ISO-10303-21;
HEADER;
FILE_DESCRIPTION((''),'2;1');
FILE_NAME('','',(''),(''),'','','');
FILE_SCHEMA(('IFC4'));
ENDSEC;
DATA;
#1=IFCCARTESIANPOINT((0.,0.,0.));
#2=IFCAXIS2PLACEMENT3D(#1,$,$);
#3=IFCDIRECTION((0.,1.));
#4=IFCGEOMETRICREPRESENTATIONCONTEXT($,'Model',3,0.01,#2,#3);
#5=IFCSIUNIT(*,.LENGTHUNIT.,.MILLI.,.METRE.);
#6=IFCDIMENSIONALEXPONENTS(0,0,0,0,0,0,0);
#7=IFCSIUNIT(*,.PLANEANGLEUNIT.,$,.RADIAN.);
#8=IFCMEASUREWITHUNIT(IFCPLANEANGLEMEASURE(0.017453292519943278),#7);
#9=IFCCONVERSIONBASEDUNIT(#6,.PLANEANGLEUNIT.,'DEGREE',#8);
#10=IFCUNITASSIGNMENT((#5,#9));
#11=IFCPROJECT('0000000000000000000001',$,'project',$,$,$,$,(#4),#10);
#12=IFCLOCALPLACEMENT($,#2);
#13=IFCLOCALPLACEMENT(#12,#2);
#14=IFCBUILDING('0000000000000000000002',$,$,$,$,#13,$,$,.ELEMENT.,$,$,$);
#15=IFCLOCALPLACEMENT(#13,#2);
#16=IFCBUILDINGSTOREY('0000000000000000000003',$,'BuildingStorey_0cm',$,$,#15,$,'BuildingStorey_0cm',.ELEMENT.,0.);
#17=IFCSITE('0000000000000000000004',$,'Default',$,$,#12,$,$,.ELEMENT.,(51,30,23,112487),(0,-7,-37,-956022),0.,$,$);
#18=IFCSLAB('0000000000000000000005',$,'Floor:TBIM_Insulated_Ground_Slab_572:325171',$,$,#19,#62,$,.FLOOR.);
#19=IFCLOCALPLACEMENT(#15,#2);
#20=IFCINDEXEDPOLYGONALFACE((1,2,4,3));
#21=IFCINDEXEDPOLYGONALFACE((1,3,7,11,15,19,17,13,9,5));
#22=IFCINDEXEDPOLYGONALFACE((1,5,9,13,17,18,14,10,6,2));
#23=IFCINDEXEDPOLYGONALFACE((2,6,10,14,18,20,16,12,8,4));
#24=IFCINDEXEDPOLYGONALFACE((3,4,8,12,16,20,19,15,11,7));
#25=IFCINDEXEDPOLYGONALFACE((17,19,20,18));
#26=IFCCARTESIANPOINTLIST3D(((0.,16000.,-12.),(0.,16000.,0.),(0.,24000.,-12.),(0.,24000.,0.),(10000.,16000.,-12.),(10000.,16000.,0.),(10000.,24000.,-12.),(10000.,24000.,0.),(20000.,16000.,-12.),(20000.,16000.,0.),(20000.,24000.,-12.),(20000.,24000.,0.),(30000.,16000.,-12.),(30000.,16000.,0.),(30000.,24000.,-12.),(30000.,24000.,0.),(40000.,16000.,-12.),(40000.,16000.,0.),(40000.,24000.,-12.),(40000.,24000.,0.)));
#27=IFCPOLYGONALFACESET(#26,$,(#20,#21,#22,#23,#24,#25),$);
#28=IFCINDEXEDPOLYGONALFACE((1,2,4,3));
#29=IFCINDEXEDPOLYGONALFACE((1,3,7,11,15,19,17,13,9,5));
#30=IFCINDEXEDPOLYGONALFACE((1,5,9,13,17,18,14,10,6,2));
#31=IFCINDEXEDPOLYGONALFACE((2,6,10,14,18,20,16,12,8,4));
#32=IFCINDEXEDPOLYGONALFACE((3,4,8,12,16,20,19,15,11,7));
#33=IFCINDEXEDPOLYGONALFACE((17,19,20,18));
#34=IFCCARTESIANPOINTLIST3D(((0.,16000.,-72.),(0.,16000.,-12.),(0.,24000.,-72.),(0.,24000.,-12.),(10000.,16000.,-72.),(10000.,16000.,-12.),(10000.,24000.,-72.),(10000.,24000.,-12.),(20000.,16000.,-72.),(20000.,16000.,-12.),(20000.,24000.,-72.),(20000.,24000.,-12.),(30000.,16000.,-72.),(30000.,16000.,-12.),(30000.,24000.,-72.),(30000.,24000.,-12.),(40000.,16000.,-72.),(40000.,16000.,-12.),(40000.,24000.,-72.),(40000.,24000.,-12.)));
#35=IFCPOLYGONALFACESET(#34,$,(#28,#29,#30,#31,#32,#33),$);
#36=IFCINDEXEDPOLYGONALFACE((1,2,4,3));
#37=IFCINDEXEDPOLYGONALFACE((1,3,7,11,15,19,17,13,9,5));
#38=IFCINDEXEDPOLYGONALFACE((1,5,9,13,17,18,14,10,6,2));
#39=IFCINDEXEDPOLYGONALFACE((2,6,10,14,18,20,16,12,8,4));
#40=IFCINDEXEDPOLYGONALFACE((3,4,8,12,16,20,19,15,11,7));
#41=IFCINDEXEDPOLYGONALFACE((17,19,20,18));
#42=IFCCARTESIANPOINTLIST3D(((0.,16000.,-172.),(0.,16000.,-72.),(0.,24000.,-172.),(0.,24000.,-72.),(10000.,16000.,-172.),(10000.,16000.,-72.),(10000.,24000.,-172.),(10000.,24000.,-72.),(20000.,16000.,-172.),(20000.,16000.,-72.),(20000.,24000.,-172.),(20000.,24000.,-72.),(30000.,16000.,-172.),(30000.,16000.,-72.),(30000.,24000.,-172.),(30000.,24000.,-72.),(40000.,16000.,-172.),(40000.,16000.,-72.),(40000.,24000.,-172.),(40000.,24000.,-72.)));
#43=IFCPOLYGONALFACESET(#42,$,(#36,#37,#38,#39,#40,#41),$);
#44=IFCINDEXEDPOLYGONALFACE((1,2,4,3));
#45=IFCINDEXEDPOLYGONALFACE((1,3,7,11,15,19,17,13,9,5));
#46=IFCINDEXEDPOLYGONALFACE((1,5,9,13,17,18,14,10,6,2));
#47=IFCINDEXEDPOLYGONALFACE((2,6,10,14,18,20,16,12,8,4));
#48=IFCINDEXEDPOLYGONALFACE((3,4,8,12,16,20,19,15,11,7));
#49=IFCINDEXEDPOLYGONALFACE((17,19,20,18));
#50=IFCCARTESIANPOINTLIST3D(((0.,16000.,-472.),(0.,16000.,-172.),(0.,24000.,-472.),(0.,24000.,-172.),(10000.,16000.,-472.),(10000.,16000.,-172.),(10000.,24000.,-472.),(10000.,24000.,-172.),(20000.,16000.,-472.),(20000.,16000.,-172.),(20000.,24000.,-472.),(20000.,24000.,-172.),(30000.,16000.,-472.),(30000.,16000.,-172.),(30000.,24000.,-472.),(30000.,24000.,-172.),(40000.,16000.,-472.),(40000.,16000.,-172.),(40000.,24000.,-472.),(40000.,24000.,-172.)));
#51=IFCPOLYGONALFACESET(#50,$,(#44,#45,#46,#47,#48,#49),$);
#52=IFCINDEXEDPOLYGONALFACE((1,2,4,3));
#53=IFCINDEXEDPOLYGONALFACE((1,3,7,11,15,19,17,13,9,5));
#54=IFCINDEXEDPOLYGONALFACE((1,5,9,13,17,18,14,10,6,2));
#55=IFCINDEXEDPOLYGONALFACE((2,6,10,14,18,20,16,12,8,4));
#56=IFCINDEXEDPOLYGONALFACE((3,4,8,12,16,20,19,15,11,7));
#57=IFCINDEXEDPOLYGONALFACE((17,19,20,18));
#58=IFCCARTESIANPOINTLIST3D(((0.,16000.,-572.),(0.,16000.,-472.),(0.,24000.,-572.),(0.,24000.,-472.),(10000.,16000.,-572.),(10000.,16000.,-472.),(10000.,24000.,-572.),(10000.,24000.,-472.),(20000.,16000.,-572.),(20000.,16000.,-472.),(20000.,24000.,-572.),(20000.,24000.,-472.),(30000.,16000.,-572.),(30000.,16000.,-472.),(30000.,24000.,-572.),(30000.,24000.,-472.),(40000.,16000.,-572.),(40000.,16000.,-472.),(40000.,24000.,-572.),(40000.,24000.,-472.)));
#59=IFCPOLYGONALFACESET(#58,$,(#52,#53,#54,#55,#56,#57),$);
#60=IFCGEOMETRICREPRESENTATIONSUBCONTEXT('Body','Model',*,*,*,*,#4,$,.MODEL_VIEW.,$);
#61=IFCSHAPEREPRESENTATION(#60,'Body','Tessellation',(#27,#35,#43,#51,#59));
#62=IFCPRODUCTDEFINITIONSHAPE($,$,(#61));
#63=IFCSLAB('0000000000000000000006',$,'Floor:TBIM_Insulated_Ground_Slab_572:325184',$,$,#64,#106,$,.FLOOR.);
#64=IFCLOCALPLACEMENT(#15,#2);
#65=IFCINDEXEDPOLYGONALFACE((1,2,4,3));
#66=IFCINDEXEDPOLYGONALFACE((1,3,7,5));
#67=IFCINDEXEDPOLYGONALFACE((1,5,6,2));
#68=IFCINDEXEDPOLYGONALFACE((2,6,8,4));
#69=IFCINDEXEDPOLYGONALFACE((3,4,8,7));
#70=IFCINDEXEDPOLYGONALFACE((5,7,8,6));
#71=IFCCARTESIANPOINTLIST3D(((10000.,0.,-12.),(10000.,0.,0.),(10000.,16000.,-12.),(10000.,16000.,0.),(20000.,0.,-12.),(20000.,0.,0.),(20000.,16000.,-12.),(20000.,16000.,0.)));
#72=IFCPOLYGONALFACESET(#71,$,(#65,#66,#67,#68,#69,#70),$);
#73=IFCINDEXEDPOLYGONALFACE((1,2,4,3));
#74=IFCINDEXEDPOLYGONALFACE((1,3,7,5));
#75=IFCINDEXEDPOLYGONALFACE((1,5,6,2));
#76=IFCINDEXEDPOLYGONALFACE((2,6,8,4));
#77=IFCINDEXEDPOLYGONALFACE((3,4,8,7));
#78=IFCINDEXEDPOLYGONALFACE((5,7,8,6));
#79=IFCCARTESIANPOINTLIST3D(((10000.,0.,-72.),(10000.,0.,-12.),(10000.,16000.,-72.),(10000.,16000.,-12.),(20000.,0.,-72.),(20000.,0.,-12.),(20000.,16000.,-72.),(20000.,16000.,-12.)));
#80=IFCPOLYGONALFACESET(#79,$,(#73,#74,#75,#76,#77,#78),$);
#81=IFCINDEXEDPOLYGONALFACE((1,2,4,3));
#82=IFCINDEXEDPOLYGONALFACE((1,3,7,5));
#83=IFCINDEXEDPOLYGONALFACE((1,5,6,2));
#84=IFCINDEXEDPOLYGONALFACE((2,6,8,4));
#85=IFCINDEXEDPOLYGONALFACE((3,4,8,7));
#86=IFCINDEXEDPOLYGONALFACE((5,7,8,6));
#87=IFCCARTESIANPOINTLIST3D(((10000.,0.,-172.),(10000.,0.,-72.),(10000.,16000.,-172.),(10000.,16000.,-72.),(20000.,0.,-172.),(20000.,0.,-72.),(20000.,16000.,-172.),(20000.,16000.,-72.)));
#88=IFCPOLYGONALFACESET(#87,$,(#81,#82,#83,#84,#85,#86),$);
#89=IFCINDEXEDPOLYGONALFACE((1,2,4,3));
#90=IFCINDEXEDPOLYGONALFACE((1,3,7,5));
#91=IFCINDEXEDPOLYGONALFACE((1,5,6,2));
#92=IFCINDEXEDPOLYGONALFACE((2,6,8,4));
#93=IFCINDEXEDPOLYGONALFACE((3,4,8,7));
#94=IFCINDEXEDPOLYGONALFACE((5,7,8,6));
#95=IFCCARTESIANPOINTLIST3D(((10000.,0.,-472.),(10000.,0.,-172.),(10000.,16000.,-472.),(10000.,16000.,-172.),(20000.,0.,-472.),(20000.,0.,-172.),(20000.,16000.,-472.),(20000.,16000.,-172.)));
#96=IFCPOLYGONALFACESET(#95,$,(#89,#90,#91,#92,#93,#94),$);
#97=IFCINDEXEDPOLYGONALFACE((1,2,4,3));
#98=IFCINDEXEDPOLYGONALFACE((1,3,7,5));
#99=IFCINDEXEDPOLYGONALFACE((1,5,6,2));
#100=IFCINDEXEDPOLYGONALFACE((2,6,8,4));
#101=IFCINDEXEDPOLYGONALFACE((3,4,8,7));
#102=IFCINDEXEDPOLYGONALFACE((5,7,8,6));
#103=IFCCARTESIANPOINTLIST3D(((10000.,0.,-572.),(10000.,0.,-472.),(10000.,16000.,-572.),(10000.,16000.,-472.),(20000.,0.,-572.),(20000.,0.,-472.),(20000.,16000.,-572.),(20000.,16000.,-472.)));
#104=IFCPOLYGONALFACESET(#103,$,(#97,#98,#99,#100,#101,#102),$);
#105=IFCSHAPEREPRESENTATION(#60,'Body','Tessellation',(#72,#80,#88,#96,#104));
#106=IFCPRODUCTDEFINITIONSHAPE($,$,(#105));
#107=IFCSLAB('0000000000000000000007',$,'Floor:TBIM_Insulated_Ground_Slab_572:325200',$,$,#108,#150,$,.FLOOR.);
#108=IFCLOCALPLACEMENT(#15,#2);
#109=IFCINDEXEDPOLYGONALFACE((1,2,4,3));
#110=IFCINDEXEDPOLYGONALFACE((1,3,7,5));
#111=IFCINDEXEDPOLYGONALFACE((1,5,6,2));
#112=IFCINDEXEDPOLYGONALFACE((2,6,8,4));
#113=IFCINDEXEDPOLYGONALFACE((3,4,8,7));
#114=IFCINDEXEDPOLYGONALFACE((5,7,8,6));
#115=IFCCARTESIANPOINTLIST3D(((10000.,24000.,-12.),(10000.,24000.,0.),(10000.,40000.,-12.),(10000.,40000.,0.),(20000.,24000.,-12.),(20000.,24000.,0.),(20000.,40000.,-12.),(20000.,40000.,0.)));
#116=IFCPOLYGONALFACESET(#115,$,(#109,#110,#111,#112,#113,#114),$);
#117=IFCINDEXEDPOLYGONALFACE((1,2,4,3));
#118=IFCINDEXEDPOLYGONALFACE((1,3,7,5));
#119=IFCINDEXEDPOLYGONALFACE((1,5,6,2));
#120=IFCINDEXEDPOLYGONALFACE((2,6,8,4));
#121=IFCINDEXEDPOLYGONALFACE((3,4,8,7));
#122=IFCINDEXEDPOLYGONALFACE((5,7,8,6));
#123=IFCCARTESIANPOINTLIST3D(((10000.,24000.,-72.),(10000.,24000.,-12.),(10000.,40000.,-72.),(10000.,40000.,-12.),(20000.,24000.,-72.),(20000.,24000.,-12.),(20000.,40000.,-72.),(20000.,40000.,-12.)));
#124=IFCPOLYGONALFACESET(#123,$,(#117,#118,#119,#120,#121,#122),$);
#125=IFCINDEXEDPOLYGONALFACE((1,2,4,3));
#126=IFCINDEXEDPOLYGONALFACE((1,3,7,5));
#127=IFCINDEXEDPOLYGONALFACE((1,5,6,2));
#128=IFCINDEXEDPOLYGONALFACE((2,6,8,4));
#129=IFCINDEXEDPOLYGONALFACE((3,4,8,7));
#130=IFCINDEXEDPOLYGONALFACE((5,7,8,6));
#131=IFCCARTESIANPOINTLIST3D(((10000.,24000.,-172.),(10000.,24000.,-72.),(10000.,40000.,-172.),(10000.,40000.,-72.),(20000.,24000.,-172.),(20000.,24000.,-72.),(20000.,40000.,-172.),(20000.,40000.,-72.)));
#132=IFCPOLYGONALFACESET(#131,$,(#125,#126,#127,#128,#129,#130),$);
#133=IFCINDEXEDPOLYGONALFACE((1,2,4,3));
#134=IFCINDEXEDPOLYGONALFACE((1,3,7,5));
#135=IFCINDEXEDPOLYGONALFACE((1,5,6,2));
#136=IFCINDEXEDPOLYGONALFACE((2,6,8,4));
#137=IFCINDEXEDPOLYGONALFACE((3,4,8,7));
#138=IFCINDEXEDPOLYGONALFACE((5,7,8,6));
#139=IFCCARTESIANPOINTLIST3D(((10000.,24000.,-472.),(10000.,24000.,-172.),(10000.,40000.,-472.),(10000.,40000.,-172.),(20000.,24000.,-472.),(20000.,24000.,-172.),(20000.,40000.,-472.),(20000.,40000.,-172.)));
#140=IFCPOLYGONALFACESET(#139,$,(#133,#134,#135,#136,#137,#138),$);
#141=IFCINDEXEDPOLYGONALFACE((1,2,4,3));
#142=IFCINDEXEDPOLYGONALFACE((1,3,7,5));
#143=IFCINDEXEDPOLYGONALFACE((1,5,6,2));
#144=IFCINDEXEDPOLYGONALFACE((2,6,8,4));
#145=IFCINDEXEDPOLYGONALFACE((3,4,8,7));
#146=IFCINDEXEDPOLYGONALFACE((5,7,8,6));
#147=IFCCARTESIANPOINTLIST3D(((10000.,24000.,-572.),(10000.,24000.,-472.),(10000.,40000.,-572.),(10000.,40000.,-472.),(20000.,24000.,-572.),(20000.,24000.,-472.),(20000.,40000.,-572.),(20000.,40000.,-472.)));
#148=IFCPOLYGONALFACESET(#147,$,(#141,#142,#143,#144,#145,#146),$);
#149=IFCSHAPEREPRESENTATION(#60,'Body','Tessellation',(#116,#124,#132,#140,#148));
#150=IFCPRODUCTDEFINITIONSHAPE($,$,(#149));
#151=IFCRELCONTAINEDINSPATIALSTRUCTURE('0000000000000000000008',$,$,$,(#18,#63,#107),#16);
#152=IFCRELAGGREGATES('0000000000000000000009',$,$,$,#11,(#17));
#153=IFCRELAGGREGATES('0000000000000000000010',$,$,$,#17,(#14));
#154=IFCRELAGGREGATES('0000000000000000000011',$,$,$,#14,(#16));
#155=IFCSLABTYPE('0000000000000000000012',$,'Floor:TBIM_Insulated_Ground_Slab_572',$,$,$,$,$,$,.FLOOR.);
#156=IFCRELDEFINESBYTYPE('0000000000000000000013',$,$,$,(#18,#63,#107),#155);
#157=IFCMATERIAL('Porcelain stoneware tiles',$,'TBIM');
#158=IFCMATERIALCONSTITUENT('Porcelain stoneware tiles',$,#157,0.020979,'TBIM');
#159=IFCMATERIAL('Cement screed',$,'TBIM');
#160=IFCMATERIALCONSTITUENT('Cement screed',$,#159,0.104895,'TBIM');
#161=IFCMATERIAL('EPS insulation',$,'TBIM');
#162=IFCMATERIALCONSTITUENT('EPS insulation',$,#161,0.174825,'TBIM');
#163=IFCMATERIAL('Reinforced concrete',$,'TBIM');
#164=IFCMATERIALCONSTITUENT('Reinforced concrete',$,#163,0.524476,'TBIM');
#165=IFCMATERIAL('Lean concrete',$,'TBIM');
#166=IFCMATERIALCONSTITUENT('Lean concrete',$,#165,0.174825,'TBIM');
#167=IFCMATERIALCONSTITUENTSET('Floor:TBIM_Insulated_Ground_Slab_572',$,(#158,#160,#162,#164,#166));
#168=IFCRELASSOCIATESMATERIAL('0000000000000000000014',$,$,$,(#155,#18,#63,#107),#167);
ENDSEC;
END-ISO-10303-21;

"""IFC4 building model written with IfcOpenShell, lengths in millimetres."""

from ifc_helpers import new_model, entity, si_unit, converted_unit, direction, frame, origin, place, context, subcontext, project, spatial, indexed_curve, outline, extrude, material, constituent, constituent_set, type_object, element, save


model = new_model("IFC4")

# Units and contexts
model_context = context("Model", 3, precision=0.01, world=origin(), true_north=direction((0.0, 1.0)))
body_context = subcontext(model_context, "Body", "Model", "MODEL_VIEW")
ifc_project = project(units=[si_unit("LENGTHUNIT", "METRE", prefix="MILLI"), converted_unit("PLANEANGLEUNIT", "DEGREE", entity("IfcPlaneAngleMeasure", 0.017453292519943278), si_unit("PLANEANGLEUNIT", "RADIAN"), dimensions=[0, 0, 0, 0, 0, 0, 0])], contexts=[model_context])

# Site, building, storey
site_placement = place(None, origin())
site = spatial("IfcSite", under=ifc_project, at=site_placement, Name="Default", CompositionType="ELEMENT", RefLatitude=(51, 30, 23, 112487), RefLongitude=(0, -7, -37, -956022), RefElevation=0.0)
building_placement = place(site_placement, origin())
building = spatial("IfcBuilding", under=site, at=building_placement, CompositionType="ELEMENT")
storey_placement = place(building_placement, origin())
storey = spatial("IfcBuildingStorey", under=building, at=storey_placement, Name="BuildingStorey_0cm", LongName="BuildingStorey_0cm", CompositionType="ELEMENT", Elevation=0.0)

# Slabs
ifc_material_1 = material(Name="Porcelain stoneware tiles", Category="TBIM")
ifc_constituent_1 = constituent(ifc_material_1, Name="Porcelain stoneware tiles", Category="TBIM", fraction=0.020979)
ifc_material_2 = material(Name="Cement screed", Category="TBIM")
ifc_constituent_2 = constituent(ifc_material_2, Name="Cement screed", Category="TBIM", fraction=0.104895)
ifc_material_3 = material(Name="EPS insulation", Category="TBIM")
ifc_constituent_3 = constituent(ifc_material_3, Name="EPS insulation", Category="TBIM", fraction=0.174825)
ifc_material_4 = material(Name="Reinforced concrete", Category="TBIM")
ifc_constituent_4 = constituent(ifc_material_4, Name="Reinforced concrete", Category="TBIM", fraction=0.524476)
ifc_material_5 = material(Name="Lean concrete", Category="TBIM")
ifc_constituent_5 = constituent(ifc_material_5, Name="Lean concrete", Category="TBIM", fraction=0.174825)
ifc_constituent_set_1 = constituent_set(constituents=[ifc_constituent_1, ifc_constituent_2, ifc_constituent_3, ifc_constituent_4, ifc_constituent_5], Name="Floor:TBIM_Insulated_Ground_Slab_572")
slab_type = type_object("IfcSlabType", Name="Floor:TBIM_Insulated_Ground_Slab_572", PredefinedType="FLOOR", material=ifc_constituent_set_1)
slab_1_placement = place(storey_placement, origin())
element("IfcSlab", 1, at=slab_1_placement, inside=storey, type_object=slab_type, material=ifc_constituent_set_1, Name="Floor:TBIM_Insulated_Ground_Slab_572:325171", PredefinedType="FLOOR", context=body_context, shape_type="SweptSolid", body=[
    extrude(outline(indexed_curve([(0.0, -4000.0), (10000.0, -4000.0), (20000.0, -4000.0), (20000.0, 4000.0), (10000.0, 4000.0), (0.0, 4000.0), (-10000.0, 4000.0), (-20000.0, 4000.0), (-20000.0, -4000.0), (-10000.0, -4000.0), (0.0, -4000.0)], self_intersect=False)), frame((20000.0, 20000.0, -12.0), z_axis=(0.0, 0.0, 1.0), x_axis=(-1.0, 0.0, 0.0)), (0.0, 0.0, 1.0), 12.0),
    extrude(outline(indexed_curve([(0.0, -4000.0), (10000.0, -4000.0), (20000.0, -4000.0), (20000.0, 4000.0), (10000.0, 4000.0), (0.0, 4000.0), (-10000.0, 4000.0), (-20000.0, 4000.0), (-20000.0, -4000.0), (-10000.0, -4000.0), (0.0, -4000.0)], self_intersect=False)), frame((20000.0, 20000.0, -72.0), z_axis=(0.0, 0.0, 1.0), x_axis=(-1.0, 0.0, 0.0)), (0.0, 0.0, 1.0), 60.0),
    extrude(outline(indexed_curve([(0.0, -4000.0), (10000.0, -4000.0), (20000.0, -4000.0), (20000.0, 4000.0), (10000.0, 4000.0), (0.0, 4000.0), (-10000.0, 4000.0), (-20000.0, 4000.0), (-20000.0, -4000.0), (-10000.0, -4000.0), (0.0, -4000.0)], self_intersect=False)), frame((20000.0, 20000.0, -172.0), z_axis=(0.0, 0.0, 1.0), x_axis=(-1.0, 0.0, 0.0)), (0.0, 0.0, 1.0), 100.0),
    extrude(outline(indexed_curve([(0.0, -4000.0), (10000.0, -4000.0), (20000.0, -4000.0), (20000.0, 4000.0), (10000.0, 4000.0), (0.0, 4000.0), (-10000.0, 4000.0), (-20000.0, 4000.0), (-20000.0, -4000.0), (-10000.0, -4000.0), (0.0, -4000.0)], self_intersect=False)), frame((20000.0, 20000.0, -472.0), z_axis=(0.0, 0.0, 1.0), x_axis=(-1.0, 0.0, 0.0)), (0.0, 0.0, 1.0), 300.0),
    extrude(outline(indexed_curve([(0.0, -4000.0), (10000.0, -4000.0), (20000.0, -4000.0), (20000.0, 4000.0), (10000.0, 4000.0), (0.0, 4000.0), (-10000.0, 4000.0), (-20000.0, 4000.0), (-20000.0, -4000.0), (-10000.0, -4000.0), (0.0, -4000.0)], self_intersect=False)), frame((20000.0, 20000.0, -572.0), z_axis=(0.0, 0.0, 1.0), x_axis=(-1.0, 0.0, 0.0)), (0.0, 0.0, 1.0), 100.0),
])
slab_2_placement = place(storey_placement, origin())
element("IfcSlab", 2, at=slab_2_placement, inside=storey, type_object=slab_type, material=ifc_constituent_set_1, Name="Floor:TBIM_Insulated_Ground_Slab_572:325184", PredefinedType="FLOOR", context=body_context, shape_type="SweptSolid", body=[
    extrude(outline(indexed_curve([(-5000.0, -8000.0), (5000.0, -8000.0), (5000.0, 8000.0), (-5000.0, 8000.0), (-5000.0, -8000.0)], self_intersect=False)), frame((15000.0, 8000.0, -12.0), z_axis=(0.0, 0.0, 1.0), x_axis=(-1.0, 0.0, 0.0)), (0.0, 0.0, 1.0), 12.0),
    extrude(outline(indexed_curve([(-5000.0, -8000.0), (5000.0, -8000.0), (5000.0, 8000.0), (-5000.0, 8000.0), (-5000.0, -8000.0)], self_intersect=False)), frame((15000.0, 8000.0, -72.0), z_axis=(0.0, 0.0, 1.0), x_axis=(-1.0, 0.0, 0.0)), (0.0, 0.0, 1.0), 60.0),
    extrude(outline(indexed_curve([(-5000.0, -8000.0), (5000.0, -8000.0), (5000.0, 8000.0), (-5000.0, 8000.0), (-5000.0, -8000.0)], self_intersect=False)), frame((15000.0, 8000.0, -172.0), z_axis=(0.0, 0.0, 1.0), x_axis=(-1.0, 0.0, 0.0)), (0.0, 0.0, 1.0), 100.0),
    extrude(outline(indexed_curve([(-5000.0, -8000.0), (5000.0, -8000.0), (5000.0, 8000.0), (-5000.0, 8000.0), (-5000.0, -8000.0)], self_intersect=False)), frame((15000.0, 8000.0, -472.0), z_axis=(0.0, 0.0, 1.0), x_axis=(-1.0, 0.0, 0.0)), (0.0, 0.0, 1.0), 300.0),
    extrude(outline(indexed_curve([(-5000.0, -8000.0), (5000.0, -8000.0), (5000.0, 8000.0), (-5000.0, 8000.0), (-5000.0, -8000.0)], self_intersect=False)), frame((15000.0, 8000.0, -572.0), z_axis=(0.0, 0.0, 1.0), x_axis=(-1.0, 0.0, 0.0)), (0.0, 0.0, 1.0), 100.0),
])
slab_3_placement = place(storey_placement, origin())
element("IfcSlab", 3, at=slab_3_placement, inside=storey, type_object=slab_type, material=ifc_constituent_set_1, Name="Floor:TBIM_Insulated_Ground_Slab_572:325200", PredefinedType="FLOOR", context=body_context, shape_type="SweptSolid", body=[
    extrude(outline(indexed_curve([(-5000.0, -8000.0), (5000.0, -8000.0), (5000.0, 8000.0), (-5000.0, 8000.0), (-5000.0, -8000.0)], self_intersect=False)), frame((15000.0, 32000.0, -12.0), z_axis=(0.0, 0.0, 1.0), x_axis=(-1.0, 0.0, 0.0)), (0.0, 0.0, 1.0), 12.0),
    extrude(outline(indexed_curve([(-5000.0, -8000.0), (5000.0, -8000.0), (5000.0, 8000.0), (-5000.0, 8000.0), (-5000.0, -8000.0)], self_intersect=False)), frame((15000.0, 32000.0, -72.0), z_axis=(0.0, 0.0, 1.0), x_axis=(-1.0, 0.0, 0.0)), (0.0, 0.0, 1.0), 60.0),
    extrude(outline(indexed_curve([(-5000.0, -8000.0), (5000.0, -8000.0), (5000.0, 8000.0), (-5000.0, 8000.0), (-5000.0, -8000.0)], self_intersect=False)), frame((15000.0, 32000.0, -172.0), z_axis=(0.0, 0.0, 1.0), x_axis=(-1.0, 0.0, 0.0)), (0.0, 0.0, 1.0), 100.0),
    extrude(outline(indexed_curve([(-5000.0, -8000.0), (5000.0, -8000.0), (5000.0, 8000.0), (-5000.0, 8000.0), (-5000.0, -8000.0)], self_intersect=False)), frame((15000.0, 32000.0, -472.0), z_axis=(0.0, 0.0, 1.0), x_axis=(-1.0, 0.0, 0.0)), (0.0, 0.0, 1.0), 300.0),
    extrude(outline(indexed_curve([(-5000.0, -8000.0), (5000.0, -8000.0), (5000.0, 8000.0), (-5000.0, 8000.0), (-5000.0, -8000.0)], self_intersect=False)), frame((15000.0, 32000.0, -572.0), z_axis=(0.0, 0.0, 1.0), x_axis=(-1.0, 0.0, 0.0)), (0.0, 0.0, 1.0), 100.0),
])

save(model, "model.ifc")
